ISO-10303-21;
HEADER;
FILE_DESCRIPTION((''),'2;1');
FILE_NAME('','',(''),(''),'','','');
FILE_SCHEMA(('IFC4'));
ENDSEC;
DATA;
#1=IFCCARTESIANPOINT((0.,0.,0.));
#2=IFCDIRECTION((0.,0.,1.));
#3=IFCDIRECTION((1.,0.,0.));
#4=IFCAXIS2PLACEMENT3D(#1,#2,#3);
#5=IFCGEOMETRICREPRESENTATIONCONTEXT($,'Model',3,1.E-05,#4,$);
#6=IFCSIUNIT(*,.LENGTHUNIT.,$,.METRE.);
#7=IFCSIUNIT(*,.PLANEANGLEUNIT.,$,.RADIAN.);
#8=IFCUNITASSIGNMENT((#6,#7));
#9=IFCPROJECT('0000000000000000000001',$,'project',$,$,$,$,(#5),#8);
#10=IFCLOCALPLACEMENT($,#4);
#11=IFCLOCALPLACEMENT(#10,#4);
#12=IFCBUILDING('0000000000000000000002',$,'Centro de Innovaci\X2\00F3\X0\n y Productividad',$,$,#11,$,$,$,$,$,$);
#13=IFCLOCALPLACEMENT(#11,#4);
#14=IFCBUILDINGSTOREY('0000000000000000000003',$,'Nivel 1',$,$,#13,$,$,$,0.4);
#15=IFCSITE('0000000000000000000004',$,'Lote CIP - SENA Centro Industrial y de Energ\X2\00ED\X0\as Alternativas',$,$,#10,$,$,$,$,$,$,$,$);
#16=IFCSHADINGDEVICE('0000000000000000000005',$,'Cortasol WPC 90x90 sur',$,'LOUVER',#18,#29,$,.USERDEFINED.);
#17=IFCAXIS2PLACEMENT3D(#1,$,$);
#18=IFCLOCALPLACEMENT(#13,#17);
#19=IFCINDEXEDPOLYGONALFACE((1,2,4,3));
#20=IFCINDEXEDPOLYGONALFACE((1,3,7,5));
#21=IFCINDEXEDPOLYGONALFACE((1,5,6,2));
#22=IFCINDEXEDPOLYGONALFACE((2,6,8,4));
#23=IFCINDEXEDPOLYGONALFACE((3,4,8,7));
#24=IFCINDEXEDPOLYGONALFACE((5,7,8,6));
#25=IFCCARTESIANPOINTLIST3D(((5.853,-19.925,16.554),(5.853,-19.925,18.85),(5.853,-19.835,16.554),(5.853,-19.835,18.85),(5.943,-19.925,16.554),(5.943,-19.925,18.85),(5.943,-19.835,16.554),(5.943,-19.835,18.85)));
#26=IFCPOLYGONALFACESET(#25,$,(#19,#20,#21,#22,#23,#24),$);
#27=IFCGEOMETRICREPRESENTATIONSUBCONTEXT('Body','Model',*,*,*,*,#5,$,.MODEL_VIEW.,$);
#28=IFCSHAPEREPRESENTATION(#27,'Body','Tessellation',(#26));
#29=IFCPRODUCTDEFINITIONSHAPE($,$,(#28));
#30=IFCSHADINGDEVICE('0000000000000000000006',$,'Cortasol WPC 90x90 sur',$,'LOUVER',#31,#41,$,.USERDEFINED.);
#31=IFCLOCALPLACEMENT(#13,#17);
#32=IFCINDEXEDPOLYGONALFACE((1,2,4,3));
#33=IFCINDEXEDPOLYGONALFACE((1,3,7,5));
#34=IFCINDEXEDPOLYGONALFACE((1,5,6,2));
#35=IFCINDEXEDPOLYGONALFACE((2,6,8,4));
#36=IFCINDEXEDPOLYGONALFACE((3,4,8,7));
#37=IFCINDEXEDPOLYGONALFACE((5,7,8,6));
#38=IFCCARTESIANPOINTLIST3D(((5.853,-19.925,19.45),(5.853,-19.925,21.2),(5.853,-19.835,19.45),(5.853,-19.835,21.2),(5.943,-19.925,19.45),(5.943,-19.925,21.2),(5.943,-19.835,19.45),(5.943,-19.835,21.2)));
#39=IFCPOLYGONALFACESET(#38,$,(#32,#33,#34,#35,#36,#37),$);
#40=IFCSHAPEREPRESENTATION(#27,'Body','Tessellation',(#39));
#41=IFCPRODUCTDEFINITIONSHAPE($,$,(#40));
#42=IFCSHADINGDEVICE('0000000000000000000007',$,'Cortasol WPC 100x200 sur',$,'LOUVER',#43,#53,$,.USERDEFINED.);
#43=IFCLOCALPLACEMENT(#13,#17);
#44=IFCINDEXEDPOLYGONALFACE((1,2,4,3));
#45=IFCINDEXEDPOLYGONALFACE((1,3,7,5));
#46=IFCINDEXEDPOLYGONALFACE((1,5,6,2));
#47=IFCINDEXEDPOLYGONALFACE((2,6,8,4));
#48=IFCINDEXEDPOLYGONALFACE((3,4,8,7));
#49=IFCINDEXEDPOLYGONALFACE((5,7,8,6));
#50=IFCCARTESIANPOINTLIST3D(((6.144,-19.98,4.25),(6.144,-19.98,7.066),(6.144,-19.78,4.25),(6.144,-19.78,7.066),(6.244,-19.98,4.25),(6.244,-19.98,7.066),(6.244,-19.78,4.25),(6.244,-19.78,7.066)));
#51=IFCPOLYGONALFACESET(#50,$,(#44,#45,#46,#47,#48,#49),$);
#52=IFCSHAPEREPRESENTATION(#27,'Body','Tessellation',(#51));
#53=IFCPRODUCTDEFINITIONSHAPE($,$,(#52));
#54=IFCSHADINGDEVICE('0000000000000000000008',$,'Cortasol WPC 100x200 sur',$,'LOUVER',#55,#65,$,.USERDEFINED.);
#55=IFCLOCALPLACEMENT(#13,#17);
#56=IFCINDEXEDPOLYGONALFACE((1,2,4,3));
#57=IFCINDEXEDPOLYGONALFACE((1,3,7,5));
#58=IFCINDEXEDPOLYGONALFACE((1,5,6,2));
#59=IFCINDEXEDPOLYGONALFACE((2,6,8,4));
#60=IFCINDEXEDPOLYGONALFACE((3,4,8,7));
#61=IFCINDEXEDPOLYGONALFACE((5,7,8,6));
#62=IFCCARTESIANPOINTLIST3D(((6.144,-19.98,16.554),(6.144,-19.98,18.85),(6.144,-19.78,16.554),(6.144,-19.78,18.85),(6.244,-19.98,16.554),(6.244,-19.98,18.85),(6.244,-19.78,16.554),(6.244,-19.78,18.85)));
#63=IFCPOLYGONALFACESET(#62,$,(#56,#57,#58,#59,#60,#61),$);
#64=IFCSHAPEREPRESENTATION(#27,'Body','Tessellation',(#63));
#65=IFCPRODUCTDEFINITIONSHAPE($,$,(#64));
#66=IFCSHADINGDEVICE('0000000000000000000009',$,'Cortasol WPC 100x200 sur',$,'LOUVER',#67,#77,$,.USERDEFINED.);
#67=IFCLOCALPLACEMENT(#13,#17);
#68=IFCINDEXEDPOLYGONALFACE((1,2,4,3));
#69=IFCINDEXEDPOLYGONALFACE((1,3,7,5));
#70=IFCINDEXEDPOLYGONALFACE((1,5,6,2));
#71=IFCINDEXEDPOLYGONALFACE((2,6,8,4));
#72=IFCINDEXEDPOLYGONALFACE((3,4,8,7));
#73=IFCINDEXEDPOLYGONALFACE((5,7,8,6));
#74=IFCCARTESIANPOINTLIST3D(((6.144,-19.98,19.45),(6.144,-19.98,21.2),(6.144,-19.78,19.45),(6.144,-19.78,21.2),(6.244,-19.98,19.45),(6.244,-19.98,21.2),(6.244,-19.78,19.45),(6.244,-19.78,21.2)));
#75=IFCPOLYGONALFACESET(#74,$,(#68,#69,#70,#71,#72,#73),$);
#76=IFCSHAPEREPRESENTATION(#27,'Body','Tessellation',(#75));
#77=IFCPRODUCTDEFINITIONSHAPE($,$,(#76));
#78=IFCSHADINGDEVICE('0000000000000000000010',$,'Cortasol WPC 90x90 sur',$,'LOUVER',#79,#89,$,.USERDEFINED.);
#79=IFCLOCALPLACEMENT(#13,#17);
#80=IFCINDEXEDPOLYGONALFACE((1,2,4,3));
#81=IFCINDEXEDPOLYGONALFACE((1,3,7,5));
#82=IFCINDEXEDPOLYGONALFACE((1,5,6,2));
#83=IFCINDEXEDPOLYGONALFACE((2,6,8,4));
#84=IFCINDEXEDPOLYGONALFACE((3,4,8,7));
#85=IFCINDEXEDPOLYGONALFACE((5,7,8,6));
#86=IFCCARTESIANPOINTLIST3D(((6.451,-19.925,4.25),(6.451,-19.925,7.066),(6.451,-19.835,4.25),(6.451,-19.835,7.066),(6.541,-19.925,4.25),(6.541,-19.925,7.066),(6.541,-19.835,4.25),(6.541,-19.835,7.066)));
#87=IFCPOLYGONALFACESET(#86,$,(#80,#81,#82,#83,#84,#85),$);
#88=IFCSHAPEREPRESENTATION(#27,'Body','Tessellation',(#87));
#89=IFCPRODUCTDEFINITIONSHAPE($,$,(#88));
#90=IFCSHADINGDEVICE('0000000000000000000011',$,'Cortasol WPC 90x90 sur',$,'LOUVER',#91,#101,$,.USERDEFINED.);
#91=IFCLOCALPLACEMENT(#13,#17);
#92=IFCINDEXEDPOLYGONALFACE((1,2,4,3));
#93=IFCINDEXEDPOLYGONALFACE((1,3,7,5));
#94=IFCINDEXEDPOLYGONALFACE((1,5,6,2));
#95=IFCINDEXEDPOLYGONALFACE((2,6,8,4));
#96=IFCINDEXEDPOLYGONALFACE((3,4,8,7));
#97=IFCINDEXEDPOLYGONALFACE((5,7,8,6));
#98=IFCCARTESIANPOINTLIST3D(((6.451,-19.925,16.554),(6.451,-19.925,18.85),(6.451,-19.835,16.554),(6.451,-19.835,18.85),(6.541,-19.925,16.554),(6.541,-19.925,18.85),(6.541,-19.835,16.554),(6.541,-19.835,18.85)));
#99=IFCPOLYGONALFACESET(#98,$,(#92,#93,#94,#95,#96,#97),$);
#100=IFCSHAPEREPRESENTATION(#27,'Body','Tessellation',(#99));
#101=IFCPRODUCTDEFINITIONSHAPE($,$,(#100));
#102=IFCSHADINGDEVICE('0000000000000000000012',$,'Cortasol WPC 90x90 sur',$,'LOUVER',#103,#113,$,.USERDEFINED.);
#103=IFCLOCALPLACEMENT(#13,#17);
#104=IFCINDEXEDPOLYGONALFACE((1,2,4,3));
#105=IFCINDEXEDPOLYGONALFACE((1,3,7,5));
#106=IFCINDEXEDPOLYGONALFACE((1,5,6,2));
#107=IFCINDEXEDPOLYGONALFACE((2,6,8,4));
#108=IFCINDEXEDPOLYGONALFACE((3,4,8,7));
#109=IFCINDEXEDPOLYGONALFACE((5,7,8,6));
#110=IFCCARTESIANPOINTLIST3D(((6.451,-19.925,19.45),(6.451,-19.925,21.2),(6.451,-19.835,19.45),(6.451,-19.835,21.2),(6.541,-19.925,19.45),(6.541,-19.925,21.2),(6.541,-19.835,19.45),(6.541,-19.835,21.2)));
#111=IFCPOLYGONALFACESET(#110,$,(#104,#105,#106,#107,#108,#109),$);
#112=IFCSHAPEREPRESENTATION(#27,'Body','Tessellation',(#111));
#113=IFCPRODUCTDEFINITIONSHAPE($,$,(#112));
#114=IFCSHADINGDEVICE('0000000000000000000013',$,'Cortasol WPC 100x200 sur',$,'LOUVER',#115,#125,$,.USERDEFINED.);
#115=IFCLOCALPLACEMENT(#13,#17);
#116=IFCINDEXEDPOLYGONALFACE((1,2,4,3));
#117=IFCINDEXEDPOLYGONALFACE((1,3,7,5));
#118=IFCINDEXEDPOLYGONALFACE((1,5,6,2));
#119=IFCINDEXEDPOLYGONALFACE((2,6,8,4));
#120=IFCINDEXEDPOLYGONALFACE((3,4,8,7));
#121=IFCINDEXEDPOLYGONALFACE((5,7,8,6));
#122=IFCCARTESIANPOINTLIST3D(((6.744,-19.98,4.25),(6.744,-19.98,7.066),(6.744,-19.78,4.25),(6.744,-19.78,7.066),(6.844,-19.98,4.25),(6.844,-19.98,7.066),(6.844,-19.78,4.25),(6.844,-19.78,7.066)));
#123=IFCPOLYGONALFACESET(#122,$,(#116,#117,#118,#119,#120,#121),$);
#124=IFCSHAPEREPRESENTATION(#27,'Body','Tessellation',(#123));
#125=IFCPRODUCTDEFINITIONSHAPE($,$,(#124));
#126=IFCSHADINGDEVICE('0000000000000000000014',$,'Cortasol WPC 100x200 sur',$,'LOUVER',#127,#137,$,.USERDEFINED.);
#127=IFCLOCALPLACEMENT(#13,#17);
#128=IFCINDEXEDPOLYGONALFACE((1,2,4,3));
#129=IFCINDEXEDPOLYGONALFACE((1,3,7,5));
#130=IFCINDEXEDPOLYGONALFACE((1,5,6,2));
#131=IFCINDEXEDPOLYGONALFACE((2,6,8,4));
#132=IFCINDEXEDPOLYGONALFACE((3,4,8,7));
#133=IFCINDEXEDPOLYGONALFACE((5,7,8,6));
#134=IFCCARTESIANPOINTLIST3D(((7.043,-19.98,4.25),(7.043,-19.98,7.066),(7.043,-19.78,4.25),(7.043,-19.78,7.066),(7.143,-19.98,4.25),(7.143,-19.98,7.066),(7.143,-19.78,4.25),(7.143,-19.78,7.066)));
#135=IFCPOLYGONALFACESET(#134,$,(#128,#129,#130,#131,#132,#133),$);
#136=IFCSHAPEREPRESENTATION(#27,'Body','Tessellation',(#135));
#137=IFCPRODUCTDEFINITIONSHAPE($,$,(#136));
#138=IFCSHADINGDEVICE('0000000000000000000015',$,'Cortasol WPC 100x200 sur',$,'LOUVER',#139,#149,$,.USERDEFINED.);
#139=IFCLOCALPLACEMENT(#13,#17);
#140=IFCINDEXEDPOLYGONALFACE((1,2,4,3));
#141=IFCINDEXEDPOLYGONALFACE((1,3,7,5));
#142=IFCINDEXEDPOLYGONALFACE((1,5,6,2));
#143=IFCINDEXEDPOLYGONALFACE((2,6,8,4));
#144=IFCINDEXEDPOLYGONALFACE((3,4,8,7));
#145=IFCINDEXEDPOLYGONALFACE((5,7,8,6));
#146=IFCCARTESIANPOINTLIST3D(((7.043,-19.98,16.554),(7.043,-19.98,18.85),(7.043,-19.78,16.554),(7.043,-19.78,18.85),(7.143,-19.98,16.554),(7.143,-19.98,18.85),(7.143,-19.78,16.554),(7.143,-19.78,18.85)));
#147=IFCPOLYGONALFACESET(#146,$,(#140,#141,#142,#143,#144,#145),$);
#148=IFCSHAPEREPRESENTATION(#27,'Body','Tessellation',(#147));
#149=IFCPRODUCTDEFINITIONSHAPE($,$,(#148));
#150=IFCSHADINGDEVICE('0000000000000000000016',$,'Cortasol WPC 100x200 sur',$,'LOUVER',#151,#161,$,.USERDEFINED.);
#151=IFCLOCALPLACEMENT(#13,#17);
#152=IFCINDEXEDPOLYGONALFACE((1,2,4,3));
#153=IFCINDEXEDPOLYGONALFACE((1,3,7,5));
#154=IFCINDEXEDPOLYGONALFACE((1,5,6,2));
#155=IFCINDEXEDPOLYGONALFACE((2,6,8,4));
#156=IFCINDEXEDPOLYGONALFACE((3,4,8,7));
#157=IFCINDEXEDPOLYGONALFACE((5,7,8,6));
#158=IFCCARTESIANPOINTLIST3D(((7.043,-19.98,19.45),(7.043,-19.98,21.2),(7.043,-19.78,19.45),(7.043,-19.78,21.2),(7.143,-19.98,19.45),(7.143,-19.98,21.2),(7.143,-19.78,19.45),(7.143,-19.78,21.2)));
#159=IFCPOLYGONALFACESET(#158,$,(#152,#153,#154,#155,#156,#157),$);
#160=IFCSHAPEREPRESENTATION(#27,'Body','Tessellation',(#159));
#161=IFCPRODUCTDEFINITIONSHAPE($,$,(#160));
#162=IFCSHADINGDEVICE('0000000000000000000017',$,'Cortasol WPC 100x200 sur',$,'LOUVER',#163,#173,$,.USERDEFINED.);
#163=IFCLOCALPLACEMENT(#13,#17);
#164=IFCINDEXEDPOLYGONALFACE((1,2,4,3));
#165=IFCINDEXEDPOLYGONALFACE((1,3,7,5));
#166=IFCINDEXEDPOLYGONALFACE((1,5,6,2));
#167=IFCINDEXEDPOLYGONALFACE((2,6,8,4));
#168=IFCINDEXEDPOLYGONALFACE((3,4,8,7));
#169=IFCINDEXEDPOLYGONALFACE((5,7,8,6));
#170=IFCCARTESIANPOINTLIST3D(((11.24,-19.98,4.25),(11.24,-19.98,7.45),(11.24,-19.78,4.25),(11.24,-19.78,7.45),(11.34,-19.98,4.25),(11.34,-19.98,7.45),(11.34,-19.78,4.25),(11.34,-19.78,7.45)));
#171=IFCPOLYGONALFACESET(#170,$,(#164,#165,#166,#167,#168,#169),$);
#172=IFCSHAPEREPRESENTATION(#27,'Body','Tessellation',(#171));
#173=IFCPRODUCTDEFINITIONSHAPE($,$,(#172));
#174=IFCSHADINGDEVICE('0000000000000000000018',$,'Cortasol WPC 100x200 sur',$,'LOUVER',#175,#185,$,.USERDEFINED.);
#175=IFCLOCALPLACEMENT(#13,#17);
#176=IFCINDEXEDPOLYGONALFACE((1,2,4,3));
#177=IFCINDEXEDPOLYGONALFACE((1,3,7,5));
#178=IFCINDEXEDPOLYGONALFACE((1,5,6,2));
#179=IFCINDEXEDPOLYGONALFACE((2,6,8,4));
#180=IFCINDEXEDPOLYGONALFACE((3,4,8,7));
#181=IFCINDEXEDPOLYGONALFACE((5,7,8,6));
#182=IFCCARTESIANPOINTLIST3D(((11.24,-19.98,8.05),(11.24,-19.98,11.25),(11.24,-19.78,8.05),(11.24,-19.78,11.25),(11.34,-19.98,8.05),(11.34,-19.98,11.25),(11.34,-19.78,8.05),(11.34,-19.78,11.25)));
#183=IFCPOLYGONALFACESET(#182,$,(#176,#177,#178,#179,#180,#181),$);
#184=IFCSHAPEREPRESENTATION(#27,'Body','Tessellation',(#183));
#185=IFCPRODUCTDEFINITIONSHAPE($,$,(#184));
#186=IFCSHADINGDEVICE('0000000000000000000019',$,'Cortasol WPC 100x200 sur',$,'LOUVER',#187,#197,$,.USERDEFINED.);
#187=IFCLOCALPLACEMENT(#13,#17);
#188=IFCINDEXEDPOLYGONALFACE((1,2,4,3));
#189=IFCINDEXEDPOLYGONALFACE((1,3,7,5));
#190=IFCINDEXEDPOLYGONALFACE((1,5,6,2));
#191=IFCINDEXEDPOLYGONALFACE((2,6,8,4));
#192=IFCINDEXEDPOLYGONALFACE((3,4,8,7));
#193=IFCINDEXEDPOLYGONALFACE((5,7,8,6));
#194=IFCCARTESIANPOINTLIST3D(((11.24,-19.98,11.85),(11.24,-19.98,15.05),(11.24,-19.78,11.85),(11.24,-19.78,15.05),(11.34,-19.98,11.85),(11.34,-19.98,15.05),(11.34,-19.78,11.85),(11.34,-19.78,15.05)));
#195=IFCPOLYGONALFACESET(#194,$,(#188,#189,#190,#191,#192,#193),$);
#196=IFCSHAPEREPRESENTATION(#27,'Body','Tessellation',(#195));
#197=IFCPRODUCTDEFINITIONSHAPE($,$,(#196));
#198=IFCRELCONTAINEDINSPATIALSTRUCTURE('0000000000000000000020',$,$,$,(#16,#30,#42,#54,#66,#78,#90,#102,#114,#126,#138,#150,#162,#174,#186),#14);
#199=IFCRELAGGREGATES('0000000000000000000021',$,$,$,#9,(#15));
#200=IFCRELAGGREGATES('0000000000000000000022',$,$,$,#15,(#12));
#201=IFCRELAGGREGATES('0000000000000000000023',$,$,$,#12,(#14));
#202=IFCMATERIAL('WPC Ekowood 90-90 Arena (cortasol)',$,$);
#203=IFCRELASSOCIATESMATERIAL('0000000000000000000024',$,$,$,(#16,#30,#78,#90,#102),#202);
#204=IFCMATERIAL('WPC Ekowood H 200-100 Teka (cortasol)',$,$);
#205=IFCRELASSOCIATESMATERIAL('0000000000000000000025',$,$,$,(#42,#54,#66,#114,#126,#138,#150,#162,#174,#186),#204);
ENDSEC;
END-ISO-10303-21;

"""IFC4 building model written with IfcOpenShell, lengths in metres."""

from ifc_helpers import new_model, si_unit, frame, origin_with_axes, place, context, subcontext, project, spatial, polyline, outline, extrude, material, element, save


model = new_model("IFC4")

# Units and contexts
model_context = context("Model", 3, precision=1e-05, world=origin_with_axes())
body_context = subcontext(model_context, "Body", "Model", "MODEL_VIEW")
ifc_project = project(units=[si_unit("LENGTHUNIT", "METRE"), si_unit("PLANEANGLEUNIT", "RADIAN")], contexts=[model_context])

# Site, building, storey
site_placement = place(None, origin_with_axes())
site = spatial("IfcSite", under=ifc_project, at=site_placement, Name="Lote CIP - SENA Centro Industrial y de Energías Alternativas")
building_placement = place(site_placement, origin_with_axes())
building = spatial("IfcBuilding", under=site, at=building_placement, Name="Centro de Innovación y Productividad")
storey_placement = place(building_placement, origin_with_axes())
storey = spatial("IfcBuildingStorey", under=building, at=storey_placement, Name="Nivel 1", Elevation=0.4)

# Shading devices
ifc_material_1 = material(Name="WPC Ekowood 90-90 Arena (cortasol)")
shading_device_1_placement = place(storey_placement, origin_with_axes())
element("IfcShadingDevice", 1, at=shading_device_1_placement, inside=storey, material=ifc_material_1, Name="Cortasol WPC 90x90 sur", ObjectType="LOUVER", PredefinedType="USERDEFINED", context=body_context, shape_type="SweptSolid", body=[
    extrude(outline(polyline([(5.853, -19.925), (5.853, -19.835), (5.943, -19.835), (5.943, -19.925), (5.853, -19.925)])), frame((0.0, 0.0, 16.554)), (0.0, 0.0, 1.0), 2.296),
])
shading_device_2_placement = place(storey_placement, origin_with_axes())
element("IfcShadingDevice", 2, at=shading_device_2_placement, inside=storey, material=ifc_material_1, Name="Cortasol WPC 90x90 sur", ObjectType="LOUVER", PredefinedType="USERDEFINED", context=body_context, shape_type="SweptSolid", body=[
    extrude(outline(polyline([(5.853, -19.925), (5.853, -19.835), (5.943, -19.835), (5.943, -19.925), (5.853, -19.925)])), frame((0.0, 0.0, 19.45)), (0.0, 0.0, 1.0), 1.75),
])
ifc_material_2 = material(Name="WPC Ekowood H 200-100 Teka (cortasol)")
shading_device_3_placement = place(storey_placement, origin_with_axes())
element("IfcShadingDevice", 3, at=shading_device_3_placement, inside=storey, material=ifc_material_2, Name="Cortasol WPC 100x200 sur", ObjectType="LOUVER", PredefinedType="USERDEFINED", context=body_context, shape_type="SweptSolid", body=[
    extrude(outline(polyline([(6.144, -19.98), (6.144, -19.78), (6.244, -19.78), (6.244, -19.98), (6.144, -19.98)])), frame((0.0, 0.0, 4.25)), (0.0, 0.0, 1.0), 2.816),
])
shading_device_4_placement = place(storey_placement, origin_with_axes())
element("IfcShadingDevice", 4, at=shading_device_4_placement, inside=storey, material=ifc_material_2, Name="Cortasol WPC 100x200 sur", ObjectType="LOUVER", PredefinedType="USERDEFINED", context=body_context, shape_type="SweptSolid", body=[
    extrude(outline(polyline([(6.144, -19.98), (6.144, -19.78), (6.244, -19.78), (6.244, -19.98), (6.144, -19.98)])), frame((0.0, 0.0, 16.554)), (0.0, 0.0, 1.0), 2.296),
])
shading_device_5_placement = place(storey_placement, origin_with_axes())
element("IfcShadingDevice", 5, at=shading_device_5_placement, inside=storey, material=ifc_material_2, Name="Cortasol WPC 100x200 sur", ObjectType="LOUVER", PredefinedType="USERDEFINED", context=body_context, shape_type="SweptSolid", body=[
    extrude(outline(polyline([(6.144, -19.98), (6.144, -19.78), (6.244, -19.78), (6.244, -19.98), (6.144, -19.98)])), frame((0.0, 0.0, 19.45)), (0.0, 0.0, 1.0), 1.75),
])
shading_device_6_placement = place(storey_placement, origin_with_axes())
element("IfcShadingDevice", 6, at=shading_device_6_placement, inside=storey, material=ifc_material_1, Name="Cortasol WPC 90x90 sur", ObjectType="LOUVER", PredefinedType="USERDEFINED", context=body_context, shape_type="SweptSolid", body=[
    extrude(outline(polyline([(6.451, -19.925), (6.451, -19.835), (6.541, -19.835), (6.541, -19.925), (6.451, -19.925)])), frame((0.0, 0.0, 4.25)), (0.0, 0.0, 1.0), 2.816),
])
shading_device_7_placement = place(storey_placement, origin_with_axes())
element("IfcShadingDevice", 7, at=shading_device_7_placement, inside=storey, material=ifc_material_1, Name="Cortasol WPC 90x90 sur", ObjectType="LOUVER", PredefinedType="USERDEFINED", context=body_context, shape_type="SweptSolid", body=[
    extrude(outline(polyline([(6.451, -19.925), (6.451, -19.835), (6.541, -19.835), (6.541, -19.925), (6.451, -19.925)])), frame((0.0, 0.0, 16.554)), (0.0, 0.0, 1.0), 2.296),
])
shading_device_8_placement = place(storey_placement, origin_with_axes())
element("IfcShadingDevice", 8, at=shading_device_8_placement, inside=storey, material=ifc_material_1, Name="Cortasol WPC 90x90 sur", ObjectType="LOUVER", PredefinedType="USERDEFINED", context=body_context, shape_type="SweptSolid", body=[
    extrude(outline(polyline([(6.451, -19.925), (6.451, -19.835), (6.541, -19.835), (6.541, -19.925), (6.451, -19.925)])), frame((0.0, 0.0, 19.45)), (0.0, 0.0, 1.0), 1.75),
])
shading_device_9_placement = place(storey_placement, origin_with_axes())
element("IfcShadingDevice", 9, at=shading_device_9_placement, inside=storey, material=ifc_material_2, Name="Cortasol WPC 100x200 sur", ObjectType="LOUVER", PredefinedType="USERDEFINED", context=body_context, shape_type="SweptSolid", body=[
    extrude(outline(polyline([(6.744, -19.98), (6.744, -19.78), (6.844, -19.78), (6.844, -19.98), (6.744, -19.98)])), frame((0.0, 0.0, 4.25)), (0.0, 0.0, 1.0), 2.816),
])
shading_device_10_placement = place(storey_placement, origin_with_axes())
element("IfcShadingDevice", 10, at=shading_device_10_placement, inside=storey, material=ifc_material_2, Name="Cortasol WPC 100x200 sur", ObjectType="LOUVER", PredefinedType="USERDEFINED", context=body_context, shape_type="SweptSolid", body=[
    extrude(outline(polyline([(7.043, -19.98), (7.043, -19.78), (7.143, -19.78), (7.143, -19.98), (7.043, -19.98)])), frame((0.0, 0.0, 4.25)), (0.0, 0.0, 1.0), 2.816),
])
shading_device_11_placement = place(storey_placement, origin_with_axes())
element("IfcShadingDevice", 11, at=shading_device_11_placement, inside=storey, material=ifc_material_2, Name="Cortasol WPC 100x200 sur", ObjectType="LOUVER", PredefinedType="USERDEFINED", context=body_context, shape_type="SweptSolid", body=[
    extrude(outline(polyline([(7.043, -19.98), (7.043, -19.78), (7.143, -19.78), (7.143, -19.98), (7.043, -19.98)])), frame((0.0, 0.0, 16.554)), (0.0, 0.0, 1.0), 2.296),
])
shading_device_12_placement = place(storey_placement, origin_with_axes())
element("IfcShadingDevice", 12, at=shading_device_12_placement, inside=storey, material=ifc_material_2, Name="Cortasol WPC 100x200 sur", ObjectType="LOUVER", PredefinedType="USERDEFINED", context=body_context, shape_type="SweptSolid", body=[
    extrude(outline(polyline([(7.043, -19.98), (7.043, -19.78), (7.143, -19.78), (7.143, -19.98), (7.043, -19.98)])), frame((0.0, 0.0, 19.45)), (0.0, 0.0, 1.0), 1.75),
])
shading_device_13_placement = place(storey_placement, origin_with_axes())
element("IfcShadingDevice", 13, at=shading_device_13_placement, inside=storey, material=ifc_material_2, Name="Cortasol WPC 100x200 sur", ObjectType="LOUVER", PredefinedType="USERDEFINED", context=body_context, shape_type="SweptSolid", body=[
    extrude(outline(polyline([(11.24, -19.98), (11.24, -19.78), (11.34, -19.78), (11.34, -19.98), (11.24, -19.98)])), frame((0.0, 0.0, 4.25)), (0.0, 0.0, 1.0), 3.2),
])
shading_device_14_placement = place(storey_placement, origin_with_axes())
element("IfcShadingDevice", 14, at=shading_device_14_placement, inside=storey, material=ifc_material_2, Name="Cortasol WPC 100x200 sur", ObjectType="LOUVER", PredefinedType="USERDEFINED", context=body_context, shape_type="SweptSolid", body=[
    extrude(outline(polyline([(11.24, -19.98), (11.24, -19.78), (11.34, -19.78), (11.34, -19.98), (11.24, -19.98)])), frame((0.0, 0.0, 8.05)), (0.0, 0.0, 1.0), 3.2),
])
shading_device_15_placement = place(storey_placement, origin_with_axes())
element("IfcShadingDevice", 15, at=shading_device_15_placement, inside=storey, material=ifc_material_2, Name="Cortasol WPC 100x200 sur", ObjectType="LOUVER", PredefinedType="USERDEFINED", context=body_context, shape_type="SweptSolid", body=[
    extrude(outline(polyline([(11.24, -19.98), (11.24, -19.78), (11.34, -19.78), (11.34, -19.98), (11.24, -19.98)])), frame((0.0, 0.0, 11.85)), (0.0, 0.0, 1.0), 3.2),
])

save(model, "model.ifc")
